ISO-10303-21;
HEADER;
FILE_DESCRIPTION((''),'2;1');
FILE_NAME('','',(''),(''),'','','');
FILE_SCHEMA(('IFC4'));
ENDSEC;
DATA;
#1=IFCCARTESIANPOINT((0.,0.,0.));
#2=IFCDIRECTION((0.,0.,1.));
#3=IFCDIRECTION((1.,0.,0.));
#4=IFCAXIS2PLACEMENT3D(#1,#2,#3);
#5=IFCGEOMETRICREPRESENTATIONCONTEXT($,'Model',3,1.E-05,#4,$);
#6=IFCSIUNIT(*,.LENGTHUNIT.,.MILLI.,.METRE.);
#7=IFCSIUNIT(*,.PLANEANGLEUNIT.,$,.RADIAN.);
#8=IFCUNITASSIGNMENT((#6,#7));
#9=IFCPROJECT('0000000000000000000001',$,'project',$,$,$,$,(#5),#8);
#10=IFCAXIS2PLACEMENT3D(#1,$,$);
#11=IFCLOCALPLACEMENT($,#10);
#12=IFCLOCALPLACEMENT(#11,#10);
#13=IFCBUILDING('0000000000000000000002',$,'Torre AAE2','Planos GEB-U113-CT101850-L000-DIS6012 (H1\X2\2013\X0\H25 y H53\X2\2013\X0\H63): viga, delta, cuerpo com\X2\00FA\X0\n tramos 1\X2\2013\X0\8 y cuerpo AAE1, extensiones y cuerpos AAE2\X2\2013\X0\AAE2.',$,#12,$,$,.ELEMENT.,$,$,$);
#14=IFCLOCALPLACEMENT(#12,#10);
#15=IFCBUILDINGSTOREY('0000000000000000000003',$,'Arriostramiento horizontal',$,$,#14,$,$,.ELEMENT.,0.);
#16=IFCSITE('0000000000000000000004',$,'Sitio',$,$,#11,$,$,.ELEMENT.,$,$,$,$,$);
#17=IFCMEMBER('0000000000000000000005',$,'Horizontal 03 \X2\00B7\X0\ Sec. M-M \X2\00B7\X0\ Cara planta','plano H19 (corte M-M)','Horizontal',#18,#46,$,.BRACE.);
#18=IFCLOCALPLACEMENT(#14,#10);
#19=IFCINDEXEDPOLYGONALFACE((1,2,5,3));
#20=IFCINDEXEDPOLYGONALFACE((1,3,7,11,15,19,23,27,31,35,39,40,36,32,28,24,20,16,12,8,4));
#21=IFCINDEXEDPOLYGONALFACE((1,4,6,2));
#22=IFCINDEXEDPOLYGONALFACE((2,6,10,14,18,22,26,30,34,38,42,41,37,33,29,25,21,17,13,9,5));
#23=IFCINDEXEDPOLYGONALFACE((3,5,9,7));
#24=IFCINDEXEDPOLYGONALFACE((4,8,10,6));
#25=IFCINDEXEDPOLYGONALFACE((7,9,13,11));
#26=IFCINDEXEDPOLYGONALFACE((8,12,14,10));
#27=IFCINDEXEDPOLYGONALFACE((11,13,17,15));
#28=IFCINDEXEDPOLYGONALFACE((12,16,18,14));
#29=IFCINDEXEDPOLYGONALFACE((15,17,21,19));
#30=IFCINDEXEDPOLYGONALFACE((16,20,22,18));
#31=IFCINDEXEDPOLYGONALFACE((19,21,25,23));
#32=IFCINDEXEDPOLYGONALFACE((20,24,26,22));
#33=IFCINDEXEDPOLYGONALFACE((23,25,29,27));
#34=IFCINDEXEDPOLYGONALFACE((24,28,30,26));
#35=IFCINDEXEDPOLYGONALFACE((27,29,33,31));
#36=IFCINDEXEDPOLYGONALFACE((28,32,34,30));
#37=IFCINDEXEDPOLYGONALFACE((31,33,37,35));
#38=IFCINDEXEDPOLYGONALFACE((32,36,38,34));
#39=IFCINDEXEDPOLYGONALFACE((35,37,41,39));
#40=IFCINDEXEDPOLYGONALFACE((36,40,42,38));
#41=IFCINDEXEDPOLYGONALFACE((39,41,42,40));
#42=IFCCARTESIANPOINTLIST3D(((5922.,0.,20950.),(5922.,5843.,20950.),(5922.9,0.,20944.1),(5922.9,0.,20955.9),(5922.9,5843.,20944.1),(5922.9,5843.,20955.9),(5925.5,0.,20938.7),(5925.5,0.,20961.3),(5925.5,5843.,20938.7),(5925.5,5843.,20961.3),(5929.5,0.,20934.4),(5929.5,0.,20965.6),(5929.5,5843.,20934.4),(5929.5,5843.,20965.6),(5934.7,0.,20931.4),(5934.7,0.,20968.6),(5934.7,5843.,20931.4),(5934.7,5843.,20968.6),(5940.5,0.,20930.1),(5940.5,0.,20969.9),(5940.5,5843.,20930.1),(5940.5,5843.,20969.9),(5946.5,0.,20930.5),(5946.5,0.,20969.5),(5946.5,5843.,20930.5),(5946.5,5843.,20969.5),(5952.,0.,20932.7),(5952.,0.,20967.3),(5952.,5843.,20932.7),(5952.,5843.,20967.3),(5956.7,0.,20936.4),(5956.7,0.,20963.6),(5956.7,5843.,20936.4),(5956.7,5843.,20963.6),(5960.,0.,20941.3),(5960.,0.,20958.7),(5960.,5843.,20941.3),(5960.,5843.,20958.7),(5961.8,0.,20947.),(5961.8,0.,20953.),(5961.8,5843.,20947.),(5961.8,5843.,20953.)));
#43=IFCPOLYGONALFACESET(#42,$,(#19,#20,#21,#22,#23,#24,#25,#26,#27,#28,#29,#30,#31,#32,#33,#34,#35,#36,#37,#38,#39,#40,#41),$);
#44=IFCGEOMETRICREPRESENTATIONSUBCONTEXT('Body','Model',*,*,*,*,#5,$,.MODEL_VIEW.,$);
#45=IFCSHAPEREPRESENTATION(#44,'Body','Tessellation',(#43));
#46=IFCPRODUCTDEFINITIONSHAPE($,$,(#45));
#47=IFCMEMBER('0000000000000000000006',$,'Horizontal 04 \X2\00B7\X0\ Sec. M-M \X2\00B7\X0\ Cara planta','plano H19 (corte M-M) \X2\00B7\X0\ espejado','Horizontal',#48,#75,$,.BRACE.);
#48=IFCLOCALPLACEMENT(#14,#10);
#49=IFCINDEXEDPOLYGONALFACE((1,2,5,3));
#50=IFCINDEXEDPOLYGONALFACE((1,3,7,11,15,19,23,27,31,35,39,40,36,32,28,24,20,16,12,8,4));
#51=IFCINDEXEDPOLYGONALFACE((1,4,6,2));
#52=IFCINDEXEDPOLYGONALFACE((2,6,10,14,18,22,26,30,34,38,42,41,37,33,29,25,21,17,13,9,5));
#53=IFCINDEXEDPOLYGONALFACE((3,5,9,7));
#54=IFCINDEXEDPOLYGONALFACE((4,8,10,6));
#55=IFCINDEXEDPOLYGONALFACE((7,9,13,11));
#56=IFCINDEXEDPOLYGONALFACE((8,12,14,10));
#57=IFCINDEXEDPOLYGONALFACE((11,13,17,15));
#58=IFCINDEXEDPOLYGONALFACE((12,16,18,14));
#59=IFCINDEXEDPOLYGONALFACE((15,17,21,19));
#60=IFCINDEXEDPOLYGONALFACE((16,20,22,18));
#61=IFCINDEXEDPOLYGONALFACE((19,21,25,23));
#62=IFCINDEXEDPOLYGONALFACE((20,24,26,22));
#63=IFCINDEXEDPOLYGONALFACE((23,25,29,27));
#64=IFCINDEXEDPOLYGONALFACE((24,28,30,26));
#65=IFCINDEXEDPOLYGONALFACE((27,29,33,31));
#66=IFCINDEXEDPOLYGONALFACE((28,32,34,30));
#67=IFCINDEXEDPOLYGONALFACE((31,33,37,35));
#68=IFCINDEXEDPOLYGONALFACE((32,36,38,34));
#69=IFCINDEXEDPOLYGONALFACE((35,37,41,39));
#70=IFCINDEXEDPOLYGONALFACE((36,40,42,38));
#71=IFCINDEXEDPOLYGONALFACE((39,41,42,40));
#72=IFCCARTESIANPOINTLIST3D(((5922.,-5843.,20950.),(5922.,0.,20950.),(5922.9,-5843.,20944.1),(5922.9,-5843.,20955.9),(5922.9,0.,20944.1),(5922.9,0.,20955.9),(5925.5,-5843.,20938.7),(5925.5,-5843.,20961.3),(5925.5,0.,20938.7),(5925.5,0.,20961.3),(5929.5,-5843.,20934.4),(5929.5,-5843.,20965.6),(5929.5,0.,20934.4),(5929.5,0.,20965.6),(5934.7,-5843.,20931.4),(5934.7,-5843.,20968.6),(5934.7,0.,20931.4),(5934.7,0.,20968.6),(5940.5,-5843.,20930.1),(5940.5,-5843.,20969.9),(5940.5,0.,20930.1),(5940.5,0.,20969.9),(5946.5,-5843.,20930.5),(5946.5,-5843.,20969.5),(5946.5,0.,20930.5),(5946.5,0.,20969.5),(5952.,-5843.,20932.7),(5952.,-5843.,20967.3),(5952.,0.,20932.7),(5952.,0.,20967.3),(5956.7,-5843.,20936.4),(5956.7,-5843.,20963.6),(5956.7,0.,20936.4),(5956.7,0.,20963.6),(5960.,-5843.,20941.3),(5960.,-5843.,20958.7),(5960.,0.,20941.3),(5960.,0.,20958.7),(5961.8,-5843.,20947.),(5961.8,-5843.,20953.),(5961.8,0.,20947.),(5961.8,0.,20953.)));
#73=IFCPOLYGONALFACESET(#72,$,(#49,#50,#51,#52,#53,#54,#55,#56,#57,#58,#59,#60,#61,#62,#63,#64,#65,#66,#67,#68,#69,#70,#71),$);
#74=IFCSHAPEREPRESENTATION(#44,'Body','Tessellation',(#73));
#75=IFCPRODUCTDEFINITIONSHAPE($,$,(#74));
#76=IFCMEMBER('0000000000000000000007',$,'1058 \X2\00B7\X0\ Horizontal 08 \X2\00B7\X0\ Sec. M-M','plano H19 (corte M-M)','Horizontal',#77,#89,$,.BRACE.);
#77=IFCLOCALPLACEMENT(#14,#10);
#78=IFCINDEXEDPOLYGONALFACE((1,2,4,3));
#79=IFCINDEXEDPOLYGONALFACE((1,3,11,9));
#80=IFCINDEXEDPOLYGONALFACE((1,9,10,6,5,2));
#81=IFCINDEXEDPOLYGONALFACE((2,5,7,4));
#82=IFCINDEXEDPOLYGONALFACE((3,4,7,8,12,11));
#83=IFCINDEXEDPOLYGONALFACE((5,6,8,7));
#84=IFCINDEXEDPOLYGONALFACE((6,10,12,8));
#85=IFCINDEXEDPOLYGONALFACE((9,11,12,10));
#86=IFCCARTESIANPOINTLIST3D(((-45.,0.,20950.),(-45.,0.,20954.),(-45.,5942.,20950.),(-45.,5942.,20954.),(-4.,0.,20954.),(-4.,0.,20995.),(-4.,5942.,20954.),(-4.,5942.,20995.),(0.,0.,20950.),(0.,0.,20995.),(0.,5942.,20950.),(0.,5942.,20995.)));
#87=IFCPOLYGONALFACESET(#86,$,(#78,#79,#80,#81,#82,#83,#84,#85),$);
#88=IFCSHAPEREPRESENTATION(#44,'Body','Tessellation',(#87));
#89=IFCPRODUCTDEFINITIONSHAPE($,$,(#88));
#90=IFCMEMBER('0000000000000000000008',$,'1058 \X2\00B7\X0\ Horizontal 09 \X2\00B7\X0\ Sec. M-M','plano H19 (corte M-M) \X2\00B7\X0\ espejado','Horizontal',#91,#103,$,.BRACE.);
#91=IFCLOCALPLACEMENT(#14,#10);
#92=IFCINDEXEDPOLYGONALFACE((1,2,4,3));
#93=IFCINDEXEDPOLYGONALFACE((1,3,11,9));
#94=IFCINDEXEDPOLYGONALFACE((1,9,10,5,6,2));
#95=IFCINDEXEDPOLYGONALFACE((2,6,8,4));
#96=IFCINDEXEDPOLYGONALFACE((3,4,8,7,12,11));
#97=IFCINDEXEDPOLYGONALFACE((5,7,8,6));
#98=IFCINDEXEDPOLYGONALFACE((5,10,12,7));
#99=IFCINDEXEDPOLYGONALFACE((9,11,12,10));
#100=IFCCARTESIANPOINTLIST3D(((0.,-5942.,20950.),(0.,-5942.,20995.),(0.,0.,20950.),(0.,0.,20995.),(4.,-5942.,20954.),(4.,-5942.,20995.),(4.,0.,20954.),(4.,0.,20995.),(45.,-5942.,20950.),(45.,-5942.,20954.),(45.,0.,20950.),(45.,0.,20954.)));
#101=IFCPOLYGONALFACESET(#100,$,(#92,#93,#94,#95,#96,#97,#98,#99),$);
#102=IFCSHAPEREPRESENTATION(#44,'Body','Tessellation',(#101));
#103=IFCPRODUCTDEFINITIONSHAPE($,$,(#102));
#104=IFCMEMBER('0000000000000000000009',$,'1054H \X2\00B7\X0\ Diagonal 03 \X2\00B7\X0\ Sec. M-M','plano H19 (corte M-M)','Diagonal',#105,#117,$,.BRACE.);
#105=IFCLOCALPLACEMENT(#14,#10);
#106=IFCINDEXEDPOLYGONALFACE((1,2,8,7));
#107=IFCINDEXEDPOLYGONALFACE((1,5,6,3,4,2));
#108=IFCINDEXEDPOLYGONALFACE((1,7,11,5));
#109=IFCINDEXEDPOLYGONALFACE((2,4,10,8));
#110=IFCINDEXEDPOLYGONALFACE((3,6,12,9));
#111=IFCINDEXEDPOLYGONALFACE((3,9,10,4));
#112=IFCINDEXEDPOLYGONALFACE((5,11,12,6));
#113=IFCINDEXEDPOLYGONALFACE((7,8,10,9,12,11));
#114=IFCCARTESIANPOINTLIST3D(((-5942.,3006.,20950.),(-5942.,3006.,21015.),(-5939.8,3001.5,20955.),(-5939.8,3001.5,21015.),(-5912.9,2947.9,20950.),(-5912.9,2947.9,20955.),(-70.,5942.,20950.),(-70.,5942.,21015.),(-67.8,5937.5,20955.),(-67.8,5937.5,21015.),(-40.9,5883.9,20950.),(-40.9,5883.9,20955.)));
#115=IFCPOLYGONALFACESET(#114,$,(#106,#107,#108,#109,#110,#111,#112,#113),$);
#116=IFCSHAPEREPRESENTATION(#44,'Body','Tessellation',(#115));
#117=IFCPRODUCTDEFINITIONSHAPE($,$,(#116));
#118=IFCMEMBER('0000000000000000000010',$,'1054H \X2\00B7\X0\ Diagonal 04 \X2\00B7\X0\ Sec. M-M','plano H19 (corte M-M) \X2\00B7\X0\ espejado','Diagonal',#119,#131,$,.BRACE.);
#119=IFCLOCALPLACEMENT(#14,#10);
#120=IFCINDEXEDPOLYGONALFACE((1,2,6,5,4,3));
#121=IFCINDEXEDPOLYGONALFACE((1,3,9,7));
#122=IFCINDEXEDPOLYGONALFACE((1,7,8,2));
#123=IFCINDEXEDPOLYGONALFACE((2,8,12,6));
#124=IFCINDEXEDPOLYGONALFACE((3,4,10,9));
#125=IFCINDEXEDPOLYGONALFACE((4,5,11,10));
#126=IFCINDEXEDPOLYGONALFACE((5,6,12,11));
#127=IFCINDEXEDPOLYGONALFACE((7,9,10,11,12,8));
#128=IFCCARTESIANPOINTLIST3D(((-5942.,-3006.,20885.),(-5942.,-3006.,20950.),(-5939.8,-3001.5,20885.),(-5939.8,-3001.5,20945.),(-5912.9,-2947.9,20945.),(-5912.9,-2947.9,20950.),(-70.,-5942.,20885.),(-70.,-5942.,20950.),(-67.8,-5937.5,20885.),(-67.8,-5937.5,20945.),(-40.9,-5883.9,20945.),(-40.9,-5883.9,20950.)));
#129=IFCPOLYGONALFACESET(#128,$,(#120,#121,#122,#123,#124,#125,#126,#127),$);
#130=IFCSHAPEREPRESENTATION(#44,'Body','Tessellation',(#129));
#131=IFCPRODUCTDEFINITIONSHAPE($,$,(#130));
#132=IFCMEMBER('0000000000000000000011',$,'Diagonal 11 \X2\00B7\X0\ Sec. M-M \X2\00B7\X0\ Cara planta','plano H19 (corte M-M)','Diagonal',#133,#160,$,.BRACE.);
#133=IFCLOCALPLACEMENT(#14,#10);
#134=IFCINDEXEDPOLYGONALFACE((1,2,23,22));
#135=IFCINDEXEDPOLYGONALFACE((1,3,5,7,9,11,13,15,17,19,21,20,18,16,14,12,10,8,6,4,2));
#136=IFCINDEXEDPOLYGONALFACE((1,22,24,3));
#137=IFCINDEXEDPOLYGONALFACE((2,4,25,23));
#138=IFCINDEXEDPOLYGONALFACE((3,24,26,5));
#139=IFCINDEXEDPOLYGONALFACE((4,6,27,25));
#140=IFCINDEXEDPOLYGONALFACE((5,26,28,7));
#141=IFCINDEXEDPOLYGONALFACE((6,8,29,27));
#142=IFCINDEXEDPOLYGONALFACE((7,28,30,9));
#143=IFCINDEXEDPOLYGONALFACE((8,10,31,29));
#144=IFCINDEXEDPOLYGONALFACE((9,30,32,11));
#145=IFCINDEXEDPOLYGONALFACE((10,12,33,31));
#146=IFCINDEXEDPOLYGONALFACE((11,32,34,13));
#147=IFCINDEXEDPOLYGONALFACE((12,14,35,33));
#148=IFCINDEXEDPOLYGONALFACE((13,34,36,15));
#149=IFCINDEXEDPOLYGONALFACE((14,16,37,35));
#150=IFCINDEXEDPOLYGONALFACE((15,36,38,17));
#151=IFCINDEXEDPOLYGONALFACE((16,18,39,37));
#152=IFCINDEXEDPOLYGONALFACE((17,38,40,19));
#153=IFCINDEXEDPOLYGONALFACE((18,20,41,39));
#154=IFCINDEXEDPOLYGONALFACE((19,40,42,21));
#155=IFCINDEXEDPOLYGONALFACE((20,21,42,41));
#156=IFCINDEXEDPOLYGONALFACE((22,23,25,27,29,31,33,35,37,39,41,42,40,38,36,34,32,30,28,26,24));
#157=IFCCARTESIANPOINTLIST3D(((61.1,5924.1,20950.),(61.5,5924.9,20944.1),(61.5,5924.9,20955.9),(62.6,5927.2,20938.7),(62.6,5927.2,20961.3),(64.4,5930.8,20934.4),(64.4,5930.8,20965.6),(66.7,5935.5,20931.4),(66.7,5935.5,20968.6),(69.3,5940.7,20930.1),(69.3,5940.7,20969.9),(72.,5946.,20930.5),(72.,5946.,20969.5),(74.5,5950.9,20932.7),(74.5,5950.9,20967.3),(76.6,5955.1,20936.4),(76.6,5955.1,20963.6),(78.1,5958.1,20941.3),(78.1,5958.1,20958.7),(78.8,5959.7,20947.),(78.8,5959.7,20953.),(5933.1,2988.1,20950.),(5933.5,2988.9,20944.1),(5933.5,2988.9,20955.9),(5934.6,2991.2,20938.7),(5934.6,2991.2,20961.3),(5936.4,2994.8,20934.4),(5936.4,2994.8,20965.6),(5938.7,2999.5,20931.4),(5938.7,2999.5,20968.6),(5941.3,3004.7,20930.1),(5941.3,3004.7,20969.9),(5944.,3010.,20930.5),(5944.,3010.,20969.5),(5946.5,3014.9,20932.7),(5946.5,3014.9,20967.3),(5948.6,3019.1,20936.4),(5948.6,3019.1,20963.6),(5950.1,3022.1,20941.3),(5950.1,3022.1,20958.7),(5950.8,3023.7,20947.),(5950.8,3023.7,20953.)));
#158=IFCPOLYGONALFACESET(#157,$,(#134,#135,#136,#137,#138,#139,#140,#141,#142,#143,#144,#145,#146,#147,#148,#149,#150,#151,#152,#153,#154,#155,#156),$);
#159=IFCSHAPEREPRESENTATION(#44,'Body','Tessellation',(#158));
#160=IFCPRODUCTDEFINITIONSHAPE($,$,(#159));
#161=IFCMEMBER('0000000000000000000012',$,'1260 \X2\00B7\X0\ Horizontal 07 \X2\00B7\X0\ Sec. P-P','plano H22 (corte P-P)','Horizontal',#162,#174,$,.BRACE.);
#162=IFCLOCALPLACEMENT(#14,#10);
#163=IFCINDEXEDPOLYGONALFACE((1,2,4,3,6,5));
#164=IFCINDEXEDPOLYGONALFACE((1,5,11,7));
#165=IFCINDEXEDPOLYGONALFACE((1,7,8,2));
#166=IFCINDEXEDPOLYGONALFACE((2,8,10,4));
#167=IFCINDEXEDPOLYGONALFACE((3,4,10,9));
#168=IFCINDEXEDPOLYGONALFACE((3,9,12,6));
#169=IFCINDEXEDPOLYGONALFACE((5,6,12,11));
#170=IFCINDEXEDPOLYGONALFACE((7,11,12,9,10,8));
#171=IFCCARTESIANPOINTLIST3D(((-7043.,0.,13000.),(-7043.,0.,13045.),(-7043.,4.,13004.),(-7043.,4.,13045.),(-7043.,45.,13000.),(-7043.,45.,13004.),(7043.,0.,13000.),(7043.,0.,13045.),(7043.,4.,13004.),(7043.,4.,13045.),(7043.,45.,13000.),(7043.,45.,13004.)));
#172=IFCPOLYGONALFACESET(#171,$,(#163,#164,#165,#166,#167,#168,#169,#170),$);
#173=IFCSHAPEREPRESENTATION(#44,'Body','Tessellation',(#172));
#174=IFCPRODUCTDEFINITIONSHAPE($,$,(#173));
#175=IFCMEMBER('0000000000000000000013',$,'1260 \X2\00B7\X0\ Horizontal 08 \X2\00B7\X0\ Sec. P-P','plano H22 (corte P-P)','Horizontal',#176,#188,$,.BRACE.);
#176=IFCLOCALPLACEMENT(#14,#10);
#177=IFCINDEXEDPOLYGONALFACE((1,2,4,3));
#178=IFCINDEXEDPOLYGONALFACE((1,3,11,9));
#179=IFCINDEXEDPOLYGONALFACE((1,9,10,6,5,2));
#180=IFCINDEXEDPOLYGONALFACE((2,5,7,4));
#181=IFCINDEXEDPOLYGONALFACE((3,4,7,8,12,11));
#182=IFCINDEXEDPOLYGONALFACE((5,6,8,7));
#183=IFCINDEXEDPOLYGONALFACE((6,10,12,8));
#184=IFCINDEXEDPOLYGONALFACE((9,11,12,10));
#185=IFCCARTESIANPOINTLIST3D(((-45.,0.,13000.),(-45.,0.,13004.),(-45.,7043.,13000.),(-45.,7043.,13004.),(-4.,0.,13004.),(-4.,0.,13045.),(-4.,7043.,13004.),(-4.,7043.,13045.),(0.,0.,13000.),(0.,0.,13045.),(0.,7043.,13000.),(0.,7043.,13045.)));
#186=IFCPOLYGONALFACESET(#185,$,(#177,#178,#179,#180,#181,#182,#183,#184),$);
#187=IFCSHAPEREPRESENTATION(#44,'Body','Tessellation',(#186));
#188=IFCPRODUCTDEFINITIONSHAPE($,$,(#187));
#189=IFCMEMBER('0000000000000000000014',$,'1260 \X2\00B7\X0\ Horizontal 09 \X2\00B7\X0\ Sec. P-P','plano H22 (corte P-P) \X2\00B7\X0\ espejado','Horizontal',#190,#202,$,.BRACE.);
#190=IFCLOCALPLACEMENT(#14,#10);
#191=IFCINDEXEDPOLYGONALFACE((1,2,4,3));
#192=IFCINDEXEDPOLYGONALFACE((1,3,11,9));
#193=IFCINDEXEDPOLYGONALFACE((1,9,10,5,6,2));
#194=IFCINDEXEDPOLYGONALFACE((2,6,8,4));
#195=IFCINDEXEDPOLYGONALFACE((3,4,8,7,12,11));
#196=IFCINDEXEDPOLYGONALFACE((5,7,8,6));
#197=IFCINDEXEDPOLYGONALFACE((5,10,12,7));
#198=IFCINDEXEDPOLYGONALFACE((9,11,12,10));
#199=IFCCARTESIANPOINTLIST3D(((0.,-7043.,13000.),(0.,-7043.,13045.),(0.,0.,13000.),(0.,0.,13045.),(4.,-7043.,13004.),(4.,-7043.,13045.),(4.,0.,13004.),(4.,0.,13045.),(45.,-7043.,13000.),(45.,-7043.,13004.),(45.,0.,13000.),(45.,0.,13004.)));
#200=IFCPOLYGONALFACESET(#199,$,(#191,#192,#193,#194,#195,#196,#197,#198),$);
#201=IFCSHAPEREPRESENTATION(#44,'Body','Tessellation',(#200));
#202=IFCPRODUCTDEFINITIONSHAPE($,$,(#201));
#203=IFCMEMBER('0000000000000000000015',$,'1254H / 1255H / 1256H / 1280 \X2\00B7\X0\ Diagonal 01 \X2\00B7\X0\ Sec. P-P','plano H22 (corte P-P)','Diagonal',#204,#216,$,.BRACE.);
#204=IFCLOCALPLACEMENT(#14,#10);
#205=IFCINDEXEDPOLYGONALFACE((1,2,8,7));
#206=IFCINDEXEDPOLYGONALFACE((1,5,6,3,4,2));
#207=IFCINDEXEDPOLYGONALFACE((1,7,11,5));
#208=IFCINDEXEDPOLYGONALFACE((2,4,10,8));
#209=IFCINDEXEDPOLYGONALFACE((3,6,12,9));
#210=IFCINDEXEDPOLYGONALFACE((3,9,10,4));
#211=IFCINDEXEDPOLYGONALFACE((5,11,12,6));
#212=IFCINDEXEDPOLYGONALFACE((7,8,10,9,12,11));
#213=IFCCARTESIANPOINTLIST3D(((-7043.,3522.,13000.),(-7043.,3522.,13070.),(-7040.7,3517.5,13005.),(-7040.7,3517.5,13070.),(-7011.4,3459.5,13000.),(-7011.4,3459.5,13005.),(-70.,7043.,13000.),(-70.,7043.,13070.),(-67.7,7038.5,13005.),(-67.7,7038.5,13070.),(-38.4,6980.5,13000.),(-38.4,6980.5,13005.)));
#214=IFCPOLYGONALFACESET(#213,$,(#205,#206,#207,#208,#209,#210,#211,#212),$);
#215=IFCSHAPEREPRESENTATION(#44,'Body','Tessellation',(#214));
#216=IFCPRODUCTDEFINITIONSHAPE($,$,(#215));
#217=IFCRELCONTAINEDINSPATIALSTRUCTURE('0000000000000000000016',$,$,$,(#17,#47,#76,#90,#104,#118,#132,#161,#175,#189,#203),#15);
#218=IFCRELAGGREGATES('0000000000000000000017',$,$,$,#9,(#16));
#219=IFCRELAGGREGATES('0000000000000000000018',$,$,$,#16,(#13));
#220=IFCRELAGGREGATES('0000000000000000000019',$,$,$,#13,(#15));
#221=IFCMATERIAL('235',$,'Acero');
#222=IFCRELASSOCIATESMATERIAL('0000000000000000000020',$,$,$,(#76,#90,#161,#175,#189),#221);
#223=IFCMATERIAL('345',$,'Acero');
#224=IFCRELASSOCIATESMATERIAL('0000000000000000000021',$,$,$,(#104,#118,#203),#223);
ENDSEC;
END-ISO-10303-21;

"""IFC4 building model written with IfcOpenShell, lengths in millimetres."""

from ifc_helpers import new_model, si_unit, frame, frame_2d, origin, origin_with_axes, place, context, subcontext, project, spatial, circle, l_section, extrude, material, element, save


model = new_model("IFC4")

# Units and contexts
model_context = context("Model", 3, precision=1e-05, world=origin_with_axes())
body_context = subcontext(model_context, "Body", "Model", "MODEL_VIEW")
ifc_project = project(units=[si_unit("LENGTHUNIT", "METRE", prefix="MILLI"), si_unit("PLANEANGLEUNIT", "RADIAN")], contexts=[model_context])

# Site, building, storey
site_placement = place(None, origin())
site = spatial("IfcSite", under=ifc_project, at=site_placement, Name="Sitio", CompositionType="ELEMENT")
building_placement = place(site_placement, origin())
building = spatial("IfcBuilding", under=site, at=building_placement, Name="Torre AAE2", Description="Planos GEB-U113-CT101850-L000-DIS6012 (H1–H25 y H53–H63): viga, delta, cuerpo común tramos 1–8 y cuerpo AAE1, extensiones y cuerpos AAE2–AAE2.", CompositionType="ELEMENT")
storey_placement = place(building_placement, origin())
storey = spatial("IfcBuildingStorey", under=building, at=storey_placement, Name="Arriostramiento horizontal", CompositionType="ELEMENT", Elevation=0.0)

# Members
for number, where, z_axis, x_axis, name, description in (
    (1, (5942.0, 5843.0, 20950.0), (0.0, -1.0, 0.0), (-1.0, 0.0, 0.0), "Horizontal 03 · Sec. M-M · Cara planta", "plano H19 (corte M-M)"),
    (2, (5942.0, -5843.0, 20950.0), (0.0, 1.0, 0.0), (-1.0, 0.0, 0.0), "Horizontal 04 · Sec. M-M · Cara planta", "plano H19 (corte M-M) · espejado"),
):
    element("IfcMember", number, at=place(storey_placement, frame(where, z_axis=z_axis, x_axis=x_axis)), inside=storey, Name=name, Description=description, ObjectType="Horizontal", PredefinedType="BRACE", context=body_context, shape_type="SweptSolid", body=[
        extrude(circle(Radius=20.0), None, (0.0, 0.0, 1.0), 5843.0),
    ])
ifc_material_1 = material(Name="235", Category="Acero")
for number, where, z_axis, x_axis, name, description in (
    (3, (0.0, 5942.0, 20950.0), (0.0, -1.0, 0.0), (0.0, 0.0, 1.0), "1058 · Horizontal 08 · Sec. M-M", "plano H19 (corte M-M)"),
    (4, (0.0, -5942.0, 20950.0), (0.0, 1.0, 0.0), (0.0, 0.0, 1.0), "1058 · Horizontal 09 · Sec. M-M", "plano H19 (corte M-M) · espejado"),
):
    element("IfcMember", number, at=place(storey_placement, frame(where, z_axis=z_axis, x_axis=x_axis)), inside=storey, material=ifc_material_1, Name=name, Description=description, ObjectType="Horizontal", PredefinedType="BRACE", context=body_context, shape_type="SweptSolid", body=[
        extrude(l_section(Depth=45.0, Width=45.0, Thickness=4.0, at=frame_2d((22.5, 22.5))), None, (0.0, 0.0, 1.0), 5942.0),
    ])
ifc_material_2 = material(Name="345", Category="Acero")
for number, where, z_axis, x_axis, name, description in (
    (5, (-70.0, 5942.0, 20950.0), (-0.894427, -0.447214, 0.0), (0.447214, -0.894427, 0.0), "1054H · Diagonal 03 · Sec. M-M", "plano H19 (corte M-M)"),
    (6, (-70.0, -5942.0, 20950.0), (-0.894427, 0.447214, 0.0), (0.447214, 0.894427, 0.0), "1054H · Diagonal 04 · Sec. M-M", "plano H19 (corte M-M) · espejado"),
):
    element("IfcMember", number, at=place(storey_placement, frame(where, z_axis=z_axis, x_axis=x_axis)), inside=storey, material=ifc_material_2, Name=name, Description=description, ObjectType="Diagonal", PredefinedType="BRACE", context=body_context, shape_type="SweptSolid", body=[
        extrude(l_section(Depth=65.0, Width=65.0, Thickness=5.0, at=frame_2d((32.5, 32.5))), None, (0.0, 0.0, 1.0), 6565.1),
    ])
member_1_placement = place(storey_placement, frame((70.0, 5942.0, 20950.0), z_axis=(0.894427, -0.447214, 0.0), x_axis=(-0.447214, -0.894427, 0.0)))
element("IfcMember", 7, at=member_1_placement, inside=storey, Name="Diagonal 11 · Sec. M-M · Cara planta", Description="plano H19 (corte M-M)", ObjectType="Diagonal", PredefinedType="BRACE", context=body_context, shape_type="SweptSolid", body=[
    extrude(circle(Radius=20.0), None, (0.0, 0.0, 1.0), 6565.1),
])
member_2_placement = place(storey_placement, frame((7043.0, 0.0, 13000.0), z_axis=(-1.0, 0.0, 0.0), x_axis=(0.0, 0.0, 1.0)))
element("IfcMember", 8, at=member_2_placement, inside=storey, material=ifc_material_1, Name="1260 · Horizontal 07 · Sec. P-P", Description="plano H22 (corte P-P)", ObjectType="Horizontal", PredefinedType="BRACE", context=body_context, shape_type="SweptSolid", body=[
    extrude(l_section(Depth=45.0, Width=45.0, Thickness=4.0, at=frame_2d((22.5, 22.5))), None, (0.0, 0.0, 1.0), 14086.0),
])
for number, where, z_axis, x_axis, name, description in (
    (9, (0.0, 7043.0, 13000.0), (0.0, -1.0, 0.0), (0.0, 0.0, 1.0), "1260 · Horizontal 08 · Sec. P-P", "plano H22 (corte P-P)"),
    (10, (0.0, -7043.0, 13000.0), (0.0, 1.0, 0.0), (0.0, 0.0, 1.0), "1260 · Horizontal 09 · Sec. P-P", "plano H22 (corte P-P) · espejado"),
):
    element("IfcMember", number, at=place(storey_placement, frame(where, z_axis=z_axis, x_axis=x_axis)), inside=storey, material=ifc_material_1, Name=name, Description=description, ObjectType="Horizontal", PredefinedType="BRACE", context=body_context, shape_type="SweptSolid", body=[
        extrude(l_section(Depth=45.0, Width=45.0, Thickness=4.0, at=frame_2d((22.5, 22.5))), None, (0.0, 0.0, 1.0), 7043.0),
    ])
for number, where, z_axis, x_axis, name in (
    (11, (-70.0, 7043.0, 13000.0), (-0.892654, -0.450743, 0.0), (0.450743, -0.892654, 0.0), "1254H / 1255H / 1256H / 1280 · Diagonal 01 · Sec. P-P"),
):
    element("IfcMember", number, at=place(storey_placement, frame(where, z_axis=z_axis, x_axis=x_axis)), inside=storey, material=ifc_material_2, Name=name, Description="plano H22 (corte P-P)", ObjectType="Diagonal", PredefinedType="BRACE", context=body_context, shape_type="SweptSolid", body=[
        extrude(l_section(Depth=70.0, Width=70.0, Thickness=5.0, at=frame_2d((35.0, 35.0))), None, (0.0, 0.0, 1.0), 7811.5),
    ])

save(model, "model.ifc")
